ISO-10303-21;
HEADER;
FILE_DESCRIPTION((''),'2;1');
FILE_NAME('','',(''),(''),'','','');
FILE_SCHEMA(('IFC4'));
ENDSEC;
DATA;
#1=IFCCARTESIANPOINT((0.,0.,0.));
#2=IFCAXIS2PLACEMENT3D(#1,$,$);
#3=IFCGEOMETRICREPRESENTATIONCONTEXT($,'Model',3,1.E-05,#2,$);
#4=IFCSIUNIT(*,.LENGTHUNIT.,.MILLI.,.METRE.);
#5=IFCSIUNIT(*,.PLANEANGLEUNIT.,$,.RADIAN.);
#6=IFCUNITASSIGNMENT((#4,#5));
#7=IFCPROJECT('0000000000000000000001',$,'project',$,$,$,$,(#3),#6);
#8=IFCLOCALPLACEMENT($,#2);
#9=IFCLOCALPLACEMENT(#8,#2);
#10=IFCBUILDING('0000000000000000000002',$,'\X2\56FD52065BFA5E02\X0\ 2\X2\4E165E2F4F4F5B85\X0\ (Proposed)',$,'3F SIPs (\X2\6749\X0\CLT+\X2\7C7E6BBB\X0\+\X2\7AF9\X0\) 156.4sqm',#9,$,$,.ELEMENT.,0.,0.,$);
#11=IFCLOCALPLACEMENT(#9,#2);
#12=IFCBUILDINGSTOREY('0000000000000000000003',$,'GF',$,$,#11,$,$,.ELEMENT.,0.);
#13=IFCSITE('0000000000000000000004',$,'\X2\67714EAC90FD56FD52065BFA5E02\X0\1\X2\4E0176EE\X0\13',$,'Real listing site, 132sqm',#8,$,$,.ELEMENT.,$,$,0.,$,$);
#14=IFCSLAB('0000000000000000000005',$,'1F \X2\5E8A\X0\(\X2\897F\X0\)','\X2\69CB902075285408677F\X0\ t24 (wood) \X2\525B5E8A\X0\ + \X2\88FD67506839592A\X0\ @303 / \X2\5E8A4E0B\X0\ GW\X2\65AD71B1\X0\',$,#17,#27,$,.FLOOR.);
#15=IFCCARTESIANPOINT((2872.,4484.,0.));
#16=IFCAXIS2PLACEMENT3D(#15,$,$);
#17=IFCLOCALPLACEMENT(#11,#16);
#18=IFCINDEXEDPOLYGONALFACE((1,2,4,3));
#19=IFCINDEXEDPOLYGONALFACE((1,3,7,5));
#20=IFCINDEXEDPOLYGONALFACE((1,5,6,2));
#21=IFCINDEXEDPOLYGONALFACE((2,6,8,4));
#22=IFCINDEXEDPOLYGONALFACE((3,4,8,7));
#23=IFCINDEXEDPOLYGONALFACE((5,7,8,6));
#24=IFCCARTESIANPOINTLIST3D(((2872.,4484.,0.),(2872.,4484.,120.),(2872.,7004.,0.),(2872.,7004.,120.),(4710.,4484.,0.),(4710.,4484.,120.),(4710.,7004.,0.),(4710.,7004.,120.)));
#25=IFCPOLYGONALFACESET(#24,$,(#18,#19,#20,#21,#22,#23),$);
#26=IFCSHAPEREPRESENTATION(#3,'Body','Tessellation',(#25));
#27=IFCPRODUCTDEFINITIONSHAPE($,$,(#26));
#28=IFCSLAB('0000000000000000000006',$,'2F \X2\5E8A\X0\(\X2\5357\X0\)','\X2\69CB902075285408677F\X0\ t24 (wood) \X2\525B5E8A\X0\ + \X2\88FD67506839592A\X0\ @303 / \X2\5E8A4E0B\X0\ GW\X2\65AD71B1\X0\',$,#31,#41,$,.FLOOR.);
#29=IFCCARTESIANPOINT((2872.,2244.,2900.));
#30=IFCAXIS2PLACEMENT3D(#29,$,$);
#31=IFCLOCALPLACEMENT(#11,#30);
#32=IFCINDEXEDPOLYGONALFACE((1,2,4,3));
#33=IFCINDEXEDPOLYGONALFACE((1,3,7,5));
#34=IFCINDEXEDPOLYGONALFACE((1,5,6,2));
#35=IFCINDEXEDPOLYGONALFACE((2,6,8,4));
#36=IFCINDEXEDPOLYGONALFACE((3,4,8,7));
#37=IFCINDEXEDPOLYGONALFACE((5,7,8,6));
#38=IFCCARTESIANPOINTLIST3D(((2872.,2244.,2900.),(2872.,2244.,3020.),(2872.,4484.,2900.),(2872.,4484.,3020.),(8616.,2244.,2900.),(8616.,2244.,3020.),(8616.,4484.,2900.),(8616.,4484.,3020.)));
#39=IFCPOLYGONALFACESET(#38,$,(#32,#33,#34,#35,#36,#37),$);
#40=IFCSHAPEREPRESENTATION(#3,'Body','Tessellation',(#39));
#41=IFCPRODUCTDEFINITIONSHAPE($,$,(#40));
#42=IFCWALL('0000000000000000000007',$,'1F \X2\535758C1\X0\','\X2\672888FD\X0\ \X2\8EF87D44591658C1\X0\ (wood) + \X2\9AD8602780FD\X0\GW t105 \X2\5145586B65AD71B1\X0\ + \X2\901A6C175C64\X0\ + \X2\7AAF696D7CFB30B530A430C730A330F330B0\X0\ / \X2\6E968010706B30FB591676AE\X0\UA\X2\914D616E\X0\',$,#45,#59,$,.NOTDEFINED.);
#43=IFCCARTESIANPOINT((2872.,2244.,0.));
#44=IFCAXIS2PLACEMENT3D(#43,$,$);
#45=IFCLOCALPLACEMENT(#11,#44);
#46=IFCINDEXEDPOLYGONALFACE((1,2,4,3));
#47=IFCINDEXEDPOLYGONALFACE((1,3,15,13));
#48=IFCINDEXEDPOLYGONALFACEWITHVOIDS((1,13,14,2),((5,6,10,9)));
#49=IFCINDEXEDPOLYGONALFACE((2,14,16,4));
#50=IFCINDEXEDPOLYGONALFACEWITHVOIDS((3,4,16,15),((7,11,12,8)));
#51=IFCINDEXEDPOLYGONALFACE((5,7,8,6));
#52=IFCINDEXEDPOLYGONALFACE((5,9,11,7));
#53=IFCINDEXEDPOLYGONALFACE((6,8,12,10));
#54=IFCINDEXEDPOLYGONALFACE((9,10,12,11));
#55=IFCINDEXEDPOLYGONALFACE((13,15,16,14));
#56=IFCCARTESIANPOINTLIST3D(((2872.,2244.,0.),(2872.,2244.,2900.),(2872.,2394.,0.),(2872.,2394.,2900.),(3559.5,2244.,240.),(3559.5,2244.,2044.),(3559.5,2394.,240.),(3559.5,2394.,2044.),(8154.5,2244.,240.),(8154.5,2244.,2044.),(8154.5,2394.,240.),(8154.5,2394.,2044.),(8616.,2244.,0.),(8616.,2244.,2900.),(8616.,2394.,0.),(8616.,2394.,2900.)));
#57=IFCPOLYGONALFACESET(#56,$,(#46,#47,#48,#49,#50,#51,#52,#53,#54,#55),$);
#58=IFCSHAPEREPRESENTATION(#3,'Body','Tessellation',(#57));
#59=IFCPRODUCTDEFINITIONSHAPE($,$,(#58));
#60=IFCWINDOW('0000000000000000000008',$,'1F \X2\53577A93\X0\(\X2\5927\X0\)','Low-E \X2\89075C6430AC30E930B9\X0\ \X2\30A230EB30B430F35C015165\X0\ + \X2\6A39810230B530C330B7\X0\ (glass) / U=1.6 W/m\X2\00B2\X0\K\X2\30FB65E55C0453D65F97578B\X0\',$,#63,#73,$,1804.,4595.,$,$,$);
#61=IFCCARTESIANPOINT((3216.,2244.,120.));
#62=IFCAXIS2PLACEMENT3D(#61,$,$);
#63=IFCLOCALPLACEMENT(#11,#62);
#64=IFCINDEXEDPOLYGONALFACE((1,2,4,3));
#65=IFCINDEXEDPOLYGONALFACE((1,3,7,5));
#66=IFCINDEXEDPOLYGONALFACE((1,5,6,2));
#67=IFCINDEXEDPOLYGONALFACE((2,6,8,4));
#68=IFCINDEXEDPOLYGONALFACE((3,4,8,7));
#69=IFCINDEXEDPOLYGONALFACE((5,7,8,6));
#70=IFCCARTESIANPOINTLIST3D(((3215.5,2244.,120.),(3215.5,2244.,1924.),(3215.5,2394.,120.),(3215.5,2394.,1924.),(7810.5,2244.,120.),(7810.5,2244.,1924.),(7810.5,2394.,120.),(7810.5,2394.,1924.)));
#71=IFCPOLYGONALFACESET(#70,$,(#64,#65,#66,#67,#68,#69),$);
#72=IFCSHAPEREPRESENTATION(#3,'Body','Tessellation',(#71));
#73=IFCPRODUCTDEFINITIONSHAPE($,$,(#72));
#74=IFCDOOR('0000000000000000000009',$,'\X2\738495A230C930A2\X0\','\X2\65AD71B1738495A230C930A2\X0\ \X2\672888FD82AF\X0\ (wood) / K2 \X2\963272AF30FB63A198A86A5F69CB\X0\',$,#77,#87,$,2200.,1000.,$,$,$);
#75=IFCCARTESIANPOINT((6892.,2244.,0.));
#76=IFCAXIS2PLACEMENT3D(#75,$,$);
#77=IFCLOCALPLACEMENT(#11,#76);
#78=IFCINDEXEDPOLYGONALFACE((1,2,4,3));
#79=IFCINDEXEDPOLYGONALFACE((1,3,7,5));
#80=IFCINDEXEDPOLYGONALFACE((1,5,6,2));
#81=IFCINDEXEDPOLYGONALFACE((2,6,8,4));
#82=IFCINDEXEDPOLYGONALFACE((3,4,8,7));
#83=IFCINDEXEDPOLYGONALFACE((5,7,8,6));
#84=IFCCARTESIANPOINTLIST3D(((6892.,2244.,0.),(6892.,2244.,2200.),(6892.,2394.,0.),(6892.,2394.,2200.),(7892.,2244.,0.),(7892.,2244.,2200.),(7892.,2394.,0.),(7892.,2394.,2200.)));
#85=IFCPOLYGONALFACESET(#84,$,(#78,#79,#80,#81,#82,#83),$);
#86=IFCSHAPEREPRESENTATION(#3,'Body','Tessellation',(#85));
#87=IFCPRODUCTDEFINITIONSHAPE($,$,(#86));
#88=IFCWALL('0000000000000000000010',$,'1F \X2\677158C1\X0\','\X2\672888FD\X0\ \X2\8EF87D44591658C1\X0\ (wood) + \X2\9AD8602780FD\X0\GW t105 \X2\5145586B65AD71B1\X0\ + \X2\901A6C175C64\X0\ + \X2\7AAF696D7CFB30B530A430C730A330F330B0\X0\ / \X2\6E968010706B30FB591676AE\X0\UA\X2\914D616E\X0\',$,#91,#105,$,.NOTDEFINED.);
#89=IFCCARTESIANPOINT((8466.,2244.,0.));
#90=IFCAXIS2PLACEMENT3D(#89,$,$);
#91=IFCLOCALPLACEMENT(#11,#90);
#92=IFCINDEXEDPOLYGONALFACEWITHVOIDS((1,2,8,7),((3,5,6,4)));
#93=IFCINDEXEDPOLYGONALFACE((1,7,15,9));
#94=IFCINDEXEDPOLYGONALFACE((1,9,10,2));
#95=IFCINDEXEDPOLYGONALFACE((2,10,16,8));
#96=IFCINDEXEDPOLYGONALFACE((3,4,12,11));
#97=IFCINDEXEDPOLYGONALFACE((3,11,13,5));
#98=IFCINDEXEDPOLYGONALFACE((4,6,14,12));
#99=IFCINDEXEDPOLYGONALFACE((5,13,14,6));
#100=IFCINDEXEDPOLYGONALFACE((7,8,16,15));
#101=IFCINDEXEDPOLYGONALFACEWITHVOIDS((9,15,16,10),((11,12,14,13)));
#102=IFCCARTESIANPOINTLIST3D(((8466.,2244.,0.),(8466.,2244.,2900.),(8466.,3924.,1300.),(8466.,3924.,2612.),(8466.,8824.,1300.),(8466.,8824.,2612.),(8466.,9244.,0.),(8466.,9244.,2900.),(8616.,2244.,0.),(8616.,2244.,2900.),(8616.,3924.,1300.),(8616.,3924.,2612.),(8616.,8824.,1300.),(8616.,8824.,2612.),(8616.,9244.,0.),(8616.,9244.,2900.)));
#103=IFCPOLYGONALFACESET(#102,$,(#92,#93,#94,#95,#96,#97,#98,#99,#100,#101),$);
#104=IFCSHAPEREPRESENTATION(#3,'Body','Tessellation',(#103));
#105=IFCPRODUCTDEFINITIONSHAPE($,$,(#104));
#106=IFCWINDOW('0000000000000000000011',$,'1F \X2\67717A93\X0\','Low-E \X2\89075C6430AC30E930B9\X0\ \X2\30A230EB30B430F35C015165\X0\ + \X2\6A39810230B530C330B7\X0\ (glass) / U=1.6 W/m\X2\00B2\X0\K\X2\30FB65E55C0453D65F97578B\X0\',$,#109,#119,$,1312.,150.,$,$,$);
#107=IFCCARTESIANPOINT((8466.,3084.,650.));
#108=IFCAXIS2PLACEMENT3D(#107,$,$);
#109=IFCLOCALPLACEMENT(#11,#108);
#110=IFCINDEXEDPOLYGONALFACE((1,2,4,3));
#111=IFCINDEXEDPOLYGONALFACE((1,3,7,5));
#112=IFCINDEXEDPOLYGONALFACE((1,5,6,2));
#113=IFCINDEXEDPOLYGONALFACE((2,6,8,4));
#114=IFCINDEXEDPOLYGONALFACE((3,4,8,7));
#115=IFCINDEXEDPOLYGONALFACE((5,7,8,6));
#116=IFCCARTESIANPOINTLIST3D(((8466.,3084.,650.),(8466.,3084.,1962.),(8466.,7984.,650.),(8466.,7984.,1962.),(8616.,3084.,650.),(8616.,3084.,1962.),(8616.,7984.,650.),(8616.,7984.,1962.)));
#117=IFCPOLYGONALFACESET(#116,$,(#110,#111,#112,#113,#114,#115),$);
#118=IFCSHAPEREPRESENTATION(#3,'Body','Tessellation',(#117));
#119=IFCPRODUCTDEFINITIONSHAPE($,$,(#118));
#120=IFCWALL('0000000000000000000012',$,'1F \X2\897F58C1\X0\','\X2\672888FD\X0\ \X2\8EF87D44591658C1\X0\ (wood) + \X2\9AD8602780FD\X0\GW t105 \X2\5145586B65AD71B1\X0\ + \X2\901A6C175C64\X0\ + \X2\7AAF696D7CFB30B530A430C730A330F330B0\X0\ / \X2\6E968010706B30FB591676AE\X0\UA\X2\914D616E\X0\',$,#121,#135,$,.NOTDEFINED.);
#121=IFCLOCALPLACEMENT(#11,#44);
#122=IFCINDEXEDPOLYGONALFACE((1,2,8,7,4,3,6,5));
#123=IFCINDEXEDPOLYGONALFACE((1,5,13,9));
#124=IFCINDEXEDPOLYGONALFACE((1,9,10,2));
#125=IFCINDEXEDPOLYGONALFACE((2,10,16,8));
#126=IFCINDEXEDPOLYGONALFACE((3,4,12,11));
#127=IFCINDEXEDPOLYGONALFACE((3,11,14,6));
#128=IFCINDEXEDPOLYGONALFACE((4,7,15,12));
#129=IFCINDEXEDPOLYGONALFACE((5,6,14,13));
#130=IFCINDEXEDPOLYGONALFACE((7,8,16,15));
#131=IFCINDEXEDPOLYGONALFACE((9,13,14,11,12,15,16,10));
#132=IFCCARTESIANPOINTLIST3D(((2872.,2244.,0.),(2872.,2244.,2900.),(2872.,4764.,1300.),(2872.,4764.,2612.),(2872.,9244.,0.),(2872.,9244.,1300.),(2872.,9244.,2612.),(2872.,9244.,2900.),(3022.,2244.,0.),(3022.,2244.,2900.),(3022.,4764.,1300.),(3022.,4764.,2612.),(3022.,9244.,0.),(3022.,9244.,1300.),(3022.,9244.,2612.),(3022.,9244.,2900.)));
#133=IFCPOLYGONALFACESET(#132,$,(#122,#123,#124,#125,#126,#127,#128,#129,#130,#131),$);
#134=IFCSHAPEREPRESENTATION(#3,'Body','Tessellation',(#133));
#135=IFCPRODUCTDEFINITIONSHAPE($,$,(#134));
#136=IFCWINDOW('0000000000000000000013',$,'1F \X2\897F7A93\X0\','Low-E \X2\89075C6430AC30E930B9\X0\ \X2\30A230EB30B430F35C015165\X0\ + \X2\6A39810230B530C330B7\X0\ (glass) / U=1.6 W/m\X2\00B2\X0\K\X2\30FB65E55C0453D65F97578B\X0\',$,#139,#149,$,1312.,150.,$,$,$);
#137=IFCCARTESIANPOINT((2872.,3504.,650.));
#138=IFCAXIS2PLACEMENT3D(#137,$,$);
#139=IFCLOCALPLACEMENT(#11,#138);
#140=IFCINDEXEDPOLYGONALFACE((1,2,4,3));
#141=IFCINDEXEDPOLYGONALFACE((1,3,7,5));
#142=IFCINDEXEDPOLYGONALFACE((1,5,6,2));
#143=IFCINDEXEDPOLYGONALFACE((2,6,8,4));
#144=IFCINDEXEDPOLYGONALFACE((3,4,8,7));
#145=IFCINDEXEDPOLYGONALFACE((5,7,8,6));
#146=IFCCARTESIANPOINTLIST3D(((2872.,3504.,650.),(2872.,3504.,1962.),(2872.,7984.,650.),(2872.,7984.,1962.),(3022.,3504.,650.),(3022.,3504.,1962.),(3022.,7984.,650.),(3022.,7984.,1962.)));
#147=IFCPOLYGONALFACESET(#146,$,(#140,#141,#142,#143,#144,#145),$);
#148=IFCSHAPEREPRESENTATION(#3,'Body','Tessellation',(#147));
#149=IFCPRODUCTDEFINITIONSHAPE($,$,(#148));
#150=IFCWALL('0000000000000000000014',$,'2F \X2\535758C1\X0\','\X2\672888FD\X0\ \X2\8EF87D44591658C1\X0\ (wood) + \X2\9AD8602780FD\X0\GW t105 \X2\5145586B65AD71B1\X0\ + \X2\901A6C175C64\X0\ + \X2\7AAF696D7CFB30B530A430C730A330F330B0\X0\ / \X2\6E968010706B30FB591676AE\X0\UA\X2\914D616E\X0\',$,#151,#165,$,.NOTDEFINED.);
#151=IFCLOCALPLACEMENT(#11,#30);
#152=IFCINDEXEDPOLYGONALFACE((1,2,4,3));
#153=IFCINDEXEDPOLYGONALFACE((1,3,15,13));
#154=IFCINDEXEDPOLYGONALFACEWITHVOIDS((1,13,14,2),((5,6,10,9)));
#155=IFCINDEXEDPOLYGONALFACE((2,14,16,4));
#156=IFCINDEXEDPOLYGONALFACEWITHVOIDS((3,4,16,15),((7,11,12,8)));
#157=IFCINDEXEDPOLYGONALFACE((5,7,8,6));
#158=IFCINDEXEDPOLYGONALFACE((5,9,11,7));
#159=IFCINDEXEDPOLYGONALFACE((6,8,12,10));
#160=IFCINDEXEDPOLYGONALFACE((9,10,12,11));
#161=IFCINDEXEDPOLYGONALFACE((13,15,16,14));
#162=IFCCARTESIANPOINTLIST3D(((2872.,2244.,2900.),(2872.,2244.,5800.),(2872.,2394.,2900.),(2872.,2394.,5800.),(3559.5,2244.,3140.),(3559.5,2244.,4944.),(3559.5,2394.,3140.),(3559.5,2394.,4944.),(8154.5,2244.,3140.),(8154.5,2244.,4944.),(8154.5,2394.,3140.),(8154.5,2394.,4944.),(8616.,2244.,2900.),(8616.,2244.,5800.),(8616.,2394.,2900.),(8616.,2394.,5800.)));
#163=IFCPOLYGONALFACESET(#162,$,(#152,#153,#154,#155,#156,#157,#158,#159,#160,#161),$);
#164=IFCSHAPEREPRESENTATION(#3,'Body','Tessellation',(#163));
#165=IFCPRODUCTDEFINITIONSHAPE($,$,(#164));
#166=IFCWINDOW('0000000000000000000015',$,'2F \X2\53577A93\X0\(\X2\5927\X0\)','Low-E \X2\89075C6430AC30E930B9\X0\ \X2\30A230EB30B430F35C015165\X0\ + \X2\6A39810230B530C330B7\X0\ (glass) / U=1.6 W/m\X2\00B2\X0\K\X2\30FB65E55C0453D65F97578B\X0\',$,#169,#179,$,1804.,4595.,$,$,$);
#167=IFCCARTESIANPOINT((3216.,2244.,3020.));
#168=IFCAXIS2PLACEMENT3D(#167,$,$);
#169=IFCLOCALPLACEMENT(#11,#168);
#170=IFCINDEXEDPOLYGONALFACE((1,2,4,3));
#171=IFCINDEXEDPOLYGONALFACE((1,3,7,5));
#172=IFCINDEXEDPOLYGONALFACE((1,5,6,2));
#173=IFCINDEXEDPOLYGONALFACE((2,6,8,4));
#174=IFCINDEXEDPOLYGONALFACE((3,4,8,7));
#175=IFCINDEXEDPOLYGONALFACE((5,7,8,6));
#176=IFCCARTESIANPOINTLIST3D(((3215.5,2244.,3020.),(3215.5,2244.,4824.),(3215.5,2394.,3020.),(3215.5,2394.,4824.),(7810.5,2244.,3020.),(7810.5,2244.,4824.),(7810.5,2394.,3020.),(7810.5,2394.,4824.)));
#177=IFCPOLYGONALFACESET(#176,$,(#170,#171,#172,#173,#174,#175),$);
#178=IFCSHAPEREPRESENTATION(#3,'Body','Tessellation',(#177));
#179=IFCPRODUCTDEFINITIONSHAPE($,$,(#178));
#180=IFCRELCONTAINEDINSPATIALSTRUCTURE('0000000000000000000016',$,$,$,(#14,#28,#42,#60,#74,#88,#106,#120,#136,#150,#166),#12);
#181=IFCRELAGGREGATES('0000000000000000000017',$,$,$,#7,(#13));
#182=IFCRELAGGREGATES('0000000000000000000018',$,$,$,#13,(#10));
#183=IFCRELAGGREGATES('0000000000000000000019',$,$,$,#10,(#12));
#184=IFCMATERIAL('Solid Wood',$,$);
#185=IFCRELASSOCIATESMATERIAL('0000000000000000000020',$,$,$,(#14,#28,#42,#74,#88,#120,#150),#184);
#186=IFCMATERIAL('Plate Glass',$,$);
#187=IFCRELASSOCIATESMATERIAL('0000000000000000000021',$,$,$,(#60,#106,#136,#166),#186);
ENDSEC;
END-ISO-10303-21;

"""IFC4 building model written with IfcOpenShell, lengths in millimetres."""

from ifc_helpers import new_model, si_unit, frame, frame_2d, origin, place, context, project, spatial, rectangle, extrude, material, element, fill, save


model = new_model("IFC4")

# Units and contexts
model_context = context("Model", 3, precision=1e-05, world=origin())
ifc_project = project(units=[si_unit("LENGTHUNIT", "METRE", prefix="MILLI"), si_unit("PLANEANGLEUNIT", "RADIAN")], contexts=[model_context])

# Site, building, storey
site_placement = place(None, origin())
site = spatial("IfcSite", under=ifc_project, at=site_placement, Name="東京都国分寺市1丁目13", ObjectType="Real listing site, 132sqm", CompositionType="ELEMENT", RefElevation=0.0)
building_placement = place(site_placement, origin())
building = spatial("IfcBuilding", under=site, at=building_placement, Name="国分寺市 2世帯住宅 (Proposed)", ObjectType="3F SIPs (杉CLT+籾殻+竹) 156.4sqm", CompositionType="ELEMENT", ElevationOfRefHeight=0.0, ElevationOfTerrain=0.0)
storey_placement = place(building_placement, origin())
storey = spatial("IfcBuildingStorey", under=building, at=storey_placement, Name="GF", CompositionType="ELEMENT", Elevation=0.0)

# Slabs
ifc_material_1 = material(Name="Solid Wood")
slab_1_placement = place(storey_placement, frame((2872.0, 4484.0, 0.0)))
element("IfcSlab", 1, at=slab_1_placement, inside=storey, material=ifc_material_1, Name="1F 床(西)", Description="構造用合板 t24 (wood) 剛床 + 製材根太 @303 / 床下 GW断熱", PredefinedType="FLOOR", context=model_context, shape_type="SweptSolid", body=[
    extrude(rectangle(XDim=1838.0, YDim=2520.0, at=frame_2d((919.0, 1260.0))), frame((2872.0, 4484.0, 0.0)), (0.0, 0.0, 1.0), 120.0),
])
slab_2_placement = place(storey_placement, frame((2872.0, 2244.0, 2900.0)))
element("IfcSlab", 2, at=slab_2_placement, inside=storey, material=ifc_material_1, Name="2F 床(南)", Description="構造用合板 t24 (wood) 剛床 + 製材根太 @303 / 床下 GW断熱", PredefinedType="FLOOR", context=model_context, shape_type="SweptSolid", body=[
    extrude(rectangle(XDim=5744.0, YDim=2240.0, at=frame_2d((2872.0, 1120.0))), frame((2872.0, 2244.0, 2900.0)), (0.0, 0.0, 1.0), 120.0),
])

# Wall, openings, window, door
wall_1_placement = place(storey_placement, frame((2872.0, 2244.0, 0.0)))
wall_1 = element("IfcWall", 3, at=wall_1_placement, inside=storey, material=ifc_material_1, Name="1F 南壁", Description="木製 軸組外壁 (wood) + 高性能GW t105 充填断熱 + 通気層 + 窯業系サイディング / 準耐火・外皮UA配慮", PredefinedType="NOTDEFINED", context=model_context, shape_type="SweptSolid", body=[
    extrude(rectangle(XDim=5744.0, YDim=150.0, at=frame_2d((2872.0, 75.0))), frame((2872.0, 2244.0, 0.0)), (0.0, 0.0, 1.0), 2900.0),
])
opening_1_placement = place(storey_placement, frame((3216.0, 2244.0, 120.0)))
opening_1 = element("IfcOpeningElement", 4, at=opening_1_placement, cuts=wall_1, PredefinedType="NOTDEFINED", context=model_context, shape_type="SweptSolid", body=[
    extrude(rectangle(XDim=4595.0, YDim=150.0, at=frame_2d((2297.0, 75.0))), frame((3216.0, 2244.0, 120.0)), (0.0, 0.0, 1.0), 1804.0),
])
opening_2_placement = place(storey_placement, frame((6892.0, 2244.0, 0.0)))
opening_2 = element("IfcOpeningElement", 5, at=opening_2_placement, cuts=wall_1, PredefinedType="NOTDEFINED", context=model_context, shape_type="SweptSolid", body=[
    extrude(rectangle(XDim=1000.0, YDim=150.0, at=frame_2d((500.0, 75.0))), frame((6892.0, 2244.0, 0.0)), (0.0, 0.0, 1.0), 2200.0),
])
ifc_material_2 = material(Name="Plate Glass")
window_1_placement = place(storey_placement, frame((3216.0, 2244.0, 120.0)))
window_1 = element("IfcWindow", 6, at=window_1_placement, inside=storey, material=ifc_material_2, Name="1F 南窓(大)", Description="Low-E 複層ガラス アルゴン封入 + 樹脂サッシ (glass) / U=1.6 W/m²K・日射取得型", OverallHeight=1804.0, OverallWidth=4595.0, context=model_context, shape_type="SweptSolid", body=[
    extrude(rectangle(XDim=4595.0, YDim=150.0, at=frame_2d((2297.0, 75.0))), frame((3216.0, 2244.0, 120.0)), (0.0, 0.0, 1.0), 1804.0),
])
fill(opening_1, window_1)
door_placement = place(storey_placement, frame((6892.0, 2244.0, 0.0)))
door = element("IfcDoor", 7, at=door_placement, inside=storey, material=ifc_material_1, Name="玄関ドア", Description="断熱玄関ドア 木製芯 (wood) / K2 防犯・採風機構", OverallHeight=2200.0, OverallWidth=1000.0, context=model_context, shape_type="SweptSolid", body=[
    extrude(rectangle(XDim=1000.0, YDim=150.0, at=frame_2d((500.0, 75.0))), frame((6892.0, 2244.0, 0.0)), (0.0, 0.0, 1.0), 2200.0),
])
fill(opening_2, door)

# Walls, openings, windows
wall_2_placement = place(storey_placement, frame((8466.0, 2244.0, 0.0)))
wall_2 = element("IfcWall", 8, at=wall_2_placement, inside=storey, material=ifc_material_1, Name="1F 東壁", Description="木製 軸組外壁 (wood) + 高性能GW t105 充填断熱 + 通気層 + 窯業系サイディング / 準耐火・外皮UA配慮", PredefinedType="NOTDEFINED", context=model_context, shape_type="SweptSolid", body=[
    extrude(rectangle(XDim=150.0, YDim=7000.0, at=frame_2d((75.0, 3500.0))), frame((8466.0, 2244.0, 0.0)), (0.0, 0.0, 1.0), 2900.0),
])
opening_3_placement = place(storey_placement, frame((8466.0, 3084.0, 650.0)))
opening_3 = element("IfcOpeningElement", 9, at=opening_3_placement, cuts=wall_2, PredefinedType="NOTDEFINED", context=model_context, shape_type="SweptSolid", body=[
    extrude(rectangle(XDim=150.0, YDim=4900.0, at=frame_2d((75.0, 2450.0))), frame((8466.0, 3084.0, 650.0)), (0.0, 0.0, 1.0), 1312.0),
])
window_2_placement = place(storey_placement, frame((8466.0, 3084.0, 650.0)))
window_2 = element("IfcWindow", 10, at=window_2_placement, inside=storey, material=ifc_material_2, Name="1F 東窓", Description="Low-E 複層ガラス アルゴン封入 + 樹脂サッシ (glass) / U=1.6 W/m²K・日射取得型", OverallHeight=1312.0, OverallWidth=150.0, context=model_context, shape_type="SweptSolid", body=[
    extrude(rectangle(XDim=150.0, YDim=4900.0, at=frame_2d((75.0, 2450.0))), frame((8466.0, 3084.0, 650.0)), (0.0, 0.0, 1.0), 1312.0),
])
fill(opening_3, window_2)
wall_3_placement = place(storey_placement, frame((2872.0, 2244.0, 0.0)))
wall_3 = element("IfcWall", 11, at=wall_3_placement, inside=storey, material=ifc_material_1, Name="1F 西壁", Description="木製 軸組外壁 (wood) + 高性能GW t105 充填断熱 + 通気層 + 窯業系サイディング / 準耐火・外皮UA配慮", PredefinedType="NOTDEFINED", context=model_context, shape_type="SweptSolid", body=[
    extrude(rectangle(XDim=150.0, YDim=7000.0, at=frame_2d((75.0, 3500.0))), frame((2872.0, 2244.0, 0.0)), (0.0, 0.0, 1.0), 2900.0),
])
opening_4_placement = place(storey_placement, frame((2872.0, 3504.0, 650.0)))
opening_4 = element("IfcOpeningElement", 12, at=opening_4_placement, cuts=wall_3, PredefinedType="NOTDEFINED", context=model_context, shape_type="SweptSolid", body=[
    extrude(rectangle(XDim=150.0, YDim=4480.0, at=frame_2d((75.0, 2240.0))), frame((2872.0, 3504.0, 650.0)), (0.0, 0.0, 1.0), 1312.0),
])
window_3_placement = place(storey_placement, frame((2872.0, 3504.0, 650.0)))
window_3 = element("IfcWindow", 13, at=window_3_placement, inside=storey, material=ifc_material_2, Name="1F 西窓", Description="Low-E 複層ガラス アルゴン封入 + 樹脂サッシ (glass) / U=1.6 W/m²K・日射取得型", OverallHeight=1312.0, OverallWidth=150.0, context=model_context, shape_type="SweptSolid", body=[
    extrude(rectangle(XDim=150.0, YDim=4480.0, at=frame_2d((75.0, 2240.0))), frame((2872.0, 3504.0, 650.0)), (0.0, 0.0, 1.0), 1312.0),
])
fill(opening_4, window_3)
wall_4_placement = place(storey_placement, frame((2872.0, 2244.0, 2900.0)))
wall_4 = element("IfcWall", 14, at=wall_4_placement, inside=storey, material=ifc_material_1, Name="2F 南壁", Description="木製 軸組外壁 (wood) + 高性能GW t105 充填断熱 + 通気層 + 窯業系サイディング / 準耐火・外皮UA配慮", PredefinedType="NOTDEFINED", context=model_context, shape_type="SweptSolid", body=[
    extrude(rectangle(XDim=5744.0, YDim=150.0, at=frame_2d((2872.0, 75.0))), frame((2872.0, 2244.0, 2900.0)), (0.0, 0.0, 1.0), 2900.0),
])
opening_5_placement = place(storey_placement, frame((3216.0, 2244.0, 3020.0)))
opening_5 = element("IfcOpeningElement", 15, at=opening_5_placement, cuts=wall_4, PredefinedType="NOTDEFINED", context=model_context, shape_type="SweptSolid", body=[
    extrude(rectangle(XDim=4595.0, YDim=150.0, at=frame_2d((2297.0, 75.0))), frame((3216.0, 2244.0, 3020.0)), (0.0, 0.0, 1.0), 1804.0),
])
window_4_placement = place(storey_placement, frame((3216.0, 2244.0, 3020.0)))
window_4 = element("IfcWindow", 16, at=window_4_placement, inside=storey, material=ifc_material_2, Name="2F 南窓(大)", Description="Low-E 複層ガラス アルゴン封入 + 樹脂サッシ (glass) / U=1.6 W/m²K・日射取得型", OverallHeight=1804.0, OverallWidth=4595.0, context=model_context, shape_type="SweptSolid", body=[
    extrude(rectangle(XDim=4595.0, YDim=150.0, at=frame_2d((2297.0, 75.0))), frame((3216.0, 2244.0, 3020.0)), (0.0, 0.0, 1.0), 1804.0),
])
fill(opening_5, window_4)

save(model, "model.ifc")
